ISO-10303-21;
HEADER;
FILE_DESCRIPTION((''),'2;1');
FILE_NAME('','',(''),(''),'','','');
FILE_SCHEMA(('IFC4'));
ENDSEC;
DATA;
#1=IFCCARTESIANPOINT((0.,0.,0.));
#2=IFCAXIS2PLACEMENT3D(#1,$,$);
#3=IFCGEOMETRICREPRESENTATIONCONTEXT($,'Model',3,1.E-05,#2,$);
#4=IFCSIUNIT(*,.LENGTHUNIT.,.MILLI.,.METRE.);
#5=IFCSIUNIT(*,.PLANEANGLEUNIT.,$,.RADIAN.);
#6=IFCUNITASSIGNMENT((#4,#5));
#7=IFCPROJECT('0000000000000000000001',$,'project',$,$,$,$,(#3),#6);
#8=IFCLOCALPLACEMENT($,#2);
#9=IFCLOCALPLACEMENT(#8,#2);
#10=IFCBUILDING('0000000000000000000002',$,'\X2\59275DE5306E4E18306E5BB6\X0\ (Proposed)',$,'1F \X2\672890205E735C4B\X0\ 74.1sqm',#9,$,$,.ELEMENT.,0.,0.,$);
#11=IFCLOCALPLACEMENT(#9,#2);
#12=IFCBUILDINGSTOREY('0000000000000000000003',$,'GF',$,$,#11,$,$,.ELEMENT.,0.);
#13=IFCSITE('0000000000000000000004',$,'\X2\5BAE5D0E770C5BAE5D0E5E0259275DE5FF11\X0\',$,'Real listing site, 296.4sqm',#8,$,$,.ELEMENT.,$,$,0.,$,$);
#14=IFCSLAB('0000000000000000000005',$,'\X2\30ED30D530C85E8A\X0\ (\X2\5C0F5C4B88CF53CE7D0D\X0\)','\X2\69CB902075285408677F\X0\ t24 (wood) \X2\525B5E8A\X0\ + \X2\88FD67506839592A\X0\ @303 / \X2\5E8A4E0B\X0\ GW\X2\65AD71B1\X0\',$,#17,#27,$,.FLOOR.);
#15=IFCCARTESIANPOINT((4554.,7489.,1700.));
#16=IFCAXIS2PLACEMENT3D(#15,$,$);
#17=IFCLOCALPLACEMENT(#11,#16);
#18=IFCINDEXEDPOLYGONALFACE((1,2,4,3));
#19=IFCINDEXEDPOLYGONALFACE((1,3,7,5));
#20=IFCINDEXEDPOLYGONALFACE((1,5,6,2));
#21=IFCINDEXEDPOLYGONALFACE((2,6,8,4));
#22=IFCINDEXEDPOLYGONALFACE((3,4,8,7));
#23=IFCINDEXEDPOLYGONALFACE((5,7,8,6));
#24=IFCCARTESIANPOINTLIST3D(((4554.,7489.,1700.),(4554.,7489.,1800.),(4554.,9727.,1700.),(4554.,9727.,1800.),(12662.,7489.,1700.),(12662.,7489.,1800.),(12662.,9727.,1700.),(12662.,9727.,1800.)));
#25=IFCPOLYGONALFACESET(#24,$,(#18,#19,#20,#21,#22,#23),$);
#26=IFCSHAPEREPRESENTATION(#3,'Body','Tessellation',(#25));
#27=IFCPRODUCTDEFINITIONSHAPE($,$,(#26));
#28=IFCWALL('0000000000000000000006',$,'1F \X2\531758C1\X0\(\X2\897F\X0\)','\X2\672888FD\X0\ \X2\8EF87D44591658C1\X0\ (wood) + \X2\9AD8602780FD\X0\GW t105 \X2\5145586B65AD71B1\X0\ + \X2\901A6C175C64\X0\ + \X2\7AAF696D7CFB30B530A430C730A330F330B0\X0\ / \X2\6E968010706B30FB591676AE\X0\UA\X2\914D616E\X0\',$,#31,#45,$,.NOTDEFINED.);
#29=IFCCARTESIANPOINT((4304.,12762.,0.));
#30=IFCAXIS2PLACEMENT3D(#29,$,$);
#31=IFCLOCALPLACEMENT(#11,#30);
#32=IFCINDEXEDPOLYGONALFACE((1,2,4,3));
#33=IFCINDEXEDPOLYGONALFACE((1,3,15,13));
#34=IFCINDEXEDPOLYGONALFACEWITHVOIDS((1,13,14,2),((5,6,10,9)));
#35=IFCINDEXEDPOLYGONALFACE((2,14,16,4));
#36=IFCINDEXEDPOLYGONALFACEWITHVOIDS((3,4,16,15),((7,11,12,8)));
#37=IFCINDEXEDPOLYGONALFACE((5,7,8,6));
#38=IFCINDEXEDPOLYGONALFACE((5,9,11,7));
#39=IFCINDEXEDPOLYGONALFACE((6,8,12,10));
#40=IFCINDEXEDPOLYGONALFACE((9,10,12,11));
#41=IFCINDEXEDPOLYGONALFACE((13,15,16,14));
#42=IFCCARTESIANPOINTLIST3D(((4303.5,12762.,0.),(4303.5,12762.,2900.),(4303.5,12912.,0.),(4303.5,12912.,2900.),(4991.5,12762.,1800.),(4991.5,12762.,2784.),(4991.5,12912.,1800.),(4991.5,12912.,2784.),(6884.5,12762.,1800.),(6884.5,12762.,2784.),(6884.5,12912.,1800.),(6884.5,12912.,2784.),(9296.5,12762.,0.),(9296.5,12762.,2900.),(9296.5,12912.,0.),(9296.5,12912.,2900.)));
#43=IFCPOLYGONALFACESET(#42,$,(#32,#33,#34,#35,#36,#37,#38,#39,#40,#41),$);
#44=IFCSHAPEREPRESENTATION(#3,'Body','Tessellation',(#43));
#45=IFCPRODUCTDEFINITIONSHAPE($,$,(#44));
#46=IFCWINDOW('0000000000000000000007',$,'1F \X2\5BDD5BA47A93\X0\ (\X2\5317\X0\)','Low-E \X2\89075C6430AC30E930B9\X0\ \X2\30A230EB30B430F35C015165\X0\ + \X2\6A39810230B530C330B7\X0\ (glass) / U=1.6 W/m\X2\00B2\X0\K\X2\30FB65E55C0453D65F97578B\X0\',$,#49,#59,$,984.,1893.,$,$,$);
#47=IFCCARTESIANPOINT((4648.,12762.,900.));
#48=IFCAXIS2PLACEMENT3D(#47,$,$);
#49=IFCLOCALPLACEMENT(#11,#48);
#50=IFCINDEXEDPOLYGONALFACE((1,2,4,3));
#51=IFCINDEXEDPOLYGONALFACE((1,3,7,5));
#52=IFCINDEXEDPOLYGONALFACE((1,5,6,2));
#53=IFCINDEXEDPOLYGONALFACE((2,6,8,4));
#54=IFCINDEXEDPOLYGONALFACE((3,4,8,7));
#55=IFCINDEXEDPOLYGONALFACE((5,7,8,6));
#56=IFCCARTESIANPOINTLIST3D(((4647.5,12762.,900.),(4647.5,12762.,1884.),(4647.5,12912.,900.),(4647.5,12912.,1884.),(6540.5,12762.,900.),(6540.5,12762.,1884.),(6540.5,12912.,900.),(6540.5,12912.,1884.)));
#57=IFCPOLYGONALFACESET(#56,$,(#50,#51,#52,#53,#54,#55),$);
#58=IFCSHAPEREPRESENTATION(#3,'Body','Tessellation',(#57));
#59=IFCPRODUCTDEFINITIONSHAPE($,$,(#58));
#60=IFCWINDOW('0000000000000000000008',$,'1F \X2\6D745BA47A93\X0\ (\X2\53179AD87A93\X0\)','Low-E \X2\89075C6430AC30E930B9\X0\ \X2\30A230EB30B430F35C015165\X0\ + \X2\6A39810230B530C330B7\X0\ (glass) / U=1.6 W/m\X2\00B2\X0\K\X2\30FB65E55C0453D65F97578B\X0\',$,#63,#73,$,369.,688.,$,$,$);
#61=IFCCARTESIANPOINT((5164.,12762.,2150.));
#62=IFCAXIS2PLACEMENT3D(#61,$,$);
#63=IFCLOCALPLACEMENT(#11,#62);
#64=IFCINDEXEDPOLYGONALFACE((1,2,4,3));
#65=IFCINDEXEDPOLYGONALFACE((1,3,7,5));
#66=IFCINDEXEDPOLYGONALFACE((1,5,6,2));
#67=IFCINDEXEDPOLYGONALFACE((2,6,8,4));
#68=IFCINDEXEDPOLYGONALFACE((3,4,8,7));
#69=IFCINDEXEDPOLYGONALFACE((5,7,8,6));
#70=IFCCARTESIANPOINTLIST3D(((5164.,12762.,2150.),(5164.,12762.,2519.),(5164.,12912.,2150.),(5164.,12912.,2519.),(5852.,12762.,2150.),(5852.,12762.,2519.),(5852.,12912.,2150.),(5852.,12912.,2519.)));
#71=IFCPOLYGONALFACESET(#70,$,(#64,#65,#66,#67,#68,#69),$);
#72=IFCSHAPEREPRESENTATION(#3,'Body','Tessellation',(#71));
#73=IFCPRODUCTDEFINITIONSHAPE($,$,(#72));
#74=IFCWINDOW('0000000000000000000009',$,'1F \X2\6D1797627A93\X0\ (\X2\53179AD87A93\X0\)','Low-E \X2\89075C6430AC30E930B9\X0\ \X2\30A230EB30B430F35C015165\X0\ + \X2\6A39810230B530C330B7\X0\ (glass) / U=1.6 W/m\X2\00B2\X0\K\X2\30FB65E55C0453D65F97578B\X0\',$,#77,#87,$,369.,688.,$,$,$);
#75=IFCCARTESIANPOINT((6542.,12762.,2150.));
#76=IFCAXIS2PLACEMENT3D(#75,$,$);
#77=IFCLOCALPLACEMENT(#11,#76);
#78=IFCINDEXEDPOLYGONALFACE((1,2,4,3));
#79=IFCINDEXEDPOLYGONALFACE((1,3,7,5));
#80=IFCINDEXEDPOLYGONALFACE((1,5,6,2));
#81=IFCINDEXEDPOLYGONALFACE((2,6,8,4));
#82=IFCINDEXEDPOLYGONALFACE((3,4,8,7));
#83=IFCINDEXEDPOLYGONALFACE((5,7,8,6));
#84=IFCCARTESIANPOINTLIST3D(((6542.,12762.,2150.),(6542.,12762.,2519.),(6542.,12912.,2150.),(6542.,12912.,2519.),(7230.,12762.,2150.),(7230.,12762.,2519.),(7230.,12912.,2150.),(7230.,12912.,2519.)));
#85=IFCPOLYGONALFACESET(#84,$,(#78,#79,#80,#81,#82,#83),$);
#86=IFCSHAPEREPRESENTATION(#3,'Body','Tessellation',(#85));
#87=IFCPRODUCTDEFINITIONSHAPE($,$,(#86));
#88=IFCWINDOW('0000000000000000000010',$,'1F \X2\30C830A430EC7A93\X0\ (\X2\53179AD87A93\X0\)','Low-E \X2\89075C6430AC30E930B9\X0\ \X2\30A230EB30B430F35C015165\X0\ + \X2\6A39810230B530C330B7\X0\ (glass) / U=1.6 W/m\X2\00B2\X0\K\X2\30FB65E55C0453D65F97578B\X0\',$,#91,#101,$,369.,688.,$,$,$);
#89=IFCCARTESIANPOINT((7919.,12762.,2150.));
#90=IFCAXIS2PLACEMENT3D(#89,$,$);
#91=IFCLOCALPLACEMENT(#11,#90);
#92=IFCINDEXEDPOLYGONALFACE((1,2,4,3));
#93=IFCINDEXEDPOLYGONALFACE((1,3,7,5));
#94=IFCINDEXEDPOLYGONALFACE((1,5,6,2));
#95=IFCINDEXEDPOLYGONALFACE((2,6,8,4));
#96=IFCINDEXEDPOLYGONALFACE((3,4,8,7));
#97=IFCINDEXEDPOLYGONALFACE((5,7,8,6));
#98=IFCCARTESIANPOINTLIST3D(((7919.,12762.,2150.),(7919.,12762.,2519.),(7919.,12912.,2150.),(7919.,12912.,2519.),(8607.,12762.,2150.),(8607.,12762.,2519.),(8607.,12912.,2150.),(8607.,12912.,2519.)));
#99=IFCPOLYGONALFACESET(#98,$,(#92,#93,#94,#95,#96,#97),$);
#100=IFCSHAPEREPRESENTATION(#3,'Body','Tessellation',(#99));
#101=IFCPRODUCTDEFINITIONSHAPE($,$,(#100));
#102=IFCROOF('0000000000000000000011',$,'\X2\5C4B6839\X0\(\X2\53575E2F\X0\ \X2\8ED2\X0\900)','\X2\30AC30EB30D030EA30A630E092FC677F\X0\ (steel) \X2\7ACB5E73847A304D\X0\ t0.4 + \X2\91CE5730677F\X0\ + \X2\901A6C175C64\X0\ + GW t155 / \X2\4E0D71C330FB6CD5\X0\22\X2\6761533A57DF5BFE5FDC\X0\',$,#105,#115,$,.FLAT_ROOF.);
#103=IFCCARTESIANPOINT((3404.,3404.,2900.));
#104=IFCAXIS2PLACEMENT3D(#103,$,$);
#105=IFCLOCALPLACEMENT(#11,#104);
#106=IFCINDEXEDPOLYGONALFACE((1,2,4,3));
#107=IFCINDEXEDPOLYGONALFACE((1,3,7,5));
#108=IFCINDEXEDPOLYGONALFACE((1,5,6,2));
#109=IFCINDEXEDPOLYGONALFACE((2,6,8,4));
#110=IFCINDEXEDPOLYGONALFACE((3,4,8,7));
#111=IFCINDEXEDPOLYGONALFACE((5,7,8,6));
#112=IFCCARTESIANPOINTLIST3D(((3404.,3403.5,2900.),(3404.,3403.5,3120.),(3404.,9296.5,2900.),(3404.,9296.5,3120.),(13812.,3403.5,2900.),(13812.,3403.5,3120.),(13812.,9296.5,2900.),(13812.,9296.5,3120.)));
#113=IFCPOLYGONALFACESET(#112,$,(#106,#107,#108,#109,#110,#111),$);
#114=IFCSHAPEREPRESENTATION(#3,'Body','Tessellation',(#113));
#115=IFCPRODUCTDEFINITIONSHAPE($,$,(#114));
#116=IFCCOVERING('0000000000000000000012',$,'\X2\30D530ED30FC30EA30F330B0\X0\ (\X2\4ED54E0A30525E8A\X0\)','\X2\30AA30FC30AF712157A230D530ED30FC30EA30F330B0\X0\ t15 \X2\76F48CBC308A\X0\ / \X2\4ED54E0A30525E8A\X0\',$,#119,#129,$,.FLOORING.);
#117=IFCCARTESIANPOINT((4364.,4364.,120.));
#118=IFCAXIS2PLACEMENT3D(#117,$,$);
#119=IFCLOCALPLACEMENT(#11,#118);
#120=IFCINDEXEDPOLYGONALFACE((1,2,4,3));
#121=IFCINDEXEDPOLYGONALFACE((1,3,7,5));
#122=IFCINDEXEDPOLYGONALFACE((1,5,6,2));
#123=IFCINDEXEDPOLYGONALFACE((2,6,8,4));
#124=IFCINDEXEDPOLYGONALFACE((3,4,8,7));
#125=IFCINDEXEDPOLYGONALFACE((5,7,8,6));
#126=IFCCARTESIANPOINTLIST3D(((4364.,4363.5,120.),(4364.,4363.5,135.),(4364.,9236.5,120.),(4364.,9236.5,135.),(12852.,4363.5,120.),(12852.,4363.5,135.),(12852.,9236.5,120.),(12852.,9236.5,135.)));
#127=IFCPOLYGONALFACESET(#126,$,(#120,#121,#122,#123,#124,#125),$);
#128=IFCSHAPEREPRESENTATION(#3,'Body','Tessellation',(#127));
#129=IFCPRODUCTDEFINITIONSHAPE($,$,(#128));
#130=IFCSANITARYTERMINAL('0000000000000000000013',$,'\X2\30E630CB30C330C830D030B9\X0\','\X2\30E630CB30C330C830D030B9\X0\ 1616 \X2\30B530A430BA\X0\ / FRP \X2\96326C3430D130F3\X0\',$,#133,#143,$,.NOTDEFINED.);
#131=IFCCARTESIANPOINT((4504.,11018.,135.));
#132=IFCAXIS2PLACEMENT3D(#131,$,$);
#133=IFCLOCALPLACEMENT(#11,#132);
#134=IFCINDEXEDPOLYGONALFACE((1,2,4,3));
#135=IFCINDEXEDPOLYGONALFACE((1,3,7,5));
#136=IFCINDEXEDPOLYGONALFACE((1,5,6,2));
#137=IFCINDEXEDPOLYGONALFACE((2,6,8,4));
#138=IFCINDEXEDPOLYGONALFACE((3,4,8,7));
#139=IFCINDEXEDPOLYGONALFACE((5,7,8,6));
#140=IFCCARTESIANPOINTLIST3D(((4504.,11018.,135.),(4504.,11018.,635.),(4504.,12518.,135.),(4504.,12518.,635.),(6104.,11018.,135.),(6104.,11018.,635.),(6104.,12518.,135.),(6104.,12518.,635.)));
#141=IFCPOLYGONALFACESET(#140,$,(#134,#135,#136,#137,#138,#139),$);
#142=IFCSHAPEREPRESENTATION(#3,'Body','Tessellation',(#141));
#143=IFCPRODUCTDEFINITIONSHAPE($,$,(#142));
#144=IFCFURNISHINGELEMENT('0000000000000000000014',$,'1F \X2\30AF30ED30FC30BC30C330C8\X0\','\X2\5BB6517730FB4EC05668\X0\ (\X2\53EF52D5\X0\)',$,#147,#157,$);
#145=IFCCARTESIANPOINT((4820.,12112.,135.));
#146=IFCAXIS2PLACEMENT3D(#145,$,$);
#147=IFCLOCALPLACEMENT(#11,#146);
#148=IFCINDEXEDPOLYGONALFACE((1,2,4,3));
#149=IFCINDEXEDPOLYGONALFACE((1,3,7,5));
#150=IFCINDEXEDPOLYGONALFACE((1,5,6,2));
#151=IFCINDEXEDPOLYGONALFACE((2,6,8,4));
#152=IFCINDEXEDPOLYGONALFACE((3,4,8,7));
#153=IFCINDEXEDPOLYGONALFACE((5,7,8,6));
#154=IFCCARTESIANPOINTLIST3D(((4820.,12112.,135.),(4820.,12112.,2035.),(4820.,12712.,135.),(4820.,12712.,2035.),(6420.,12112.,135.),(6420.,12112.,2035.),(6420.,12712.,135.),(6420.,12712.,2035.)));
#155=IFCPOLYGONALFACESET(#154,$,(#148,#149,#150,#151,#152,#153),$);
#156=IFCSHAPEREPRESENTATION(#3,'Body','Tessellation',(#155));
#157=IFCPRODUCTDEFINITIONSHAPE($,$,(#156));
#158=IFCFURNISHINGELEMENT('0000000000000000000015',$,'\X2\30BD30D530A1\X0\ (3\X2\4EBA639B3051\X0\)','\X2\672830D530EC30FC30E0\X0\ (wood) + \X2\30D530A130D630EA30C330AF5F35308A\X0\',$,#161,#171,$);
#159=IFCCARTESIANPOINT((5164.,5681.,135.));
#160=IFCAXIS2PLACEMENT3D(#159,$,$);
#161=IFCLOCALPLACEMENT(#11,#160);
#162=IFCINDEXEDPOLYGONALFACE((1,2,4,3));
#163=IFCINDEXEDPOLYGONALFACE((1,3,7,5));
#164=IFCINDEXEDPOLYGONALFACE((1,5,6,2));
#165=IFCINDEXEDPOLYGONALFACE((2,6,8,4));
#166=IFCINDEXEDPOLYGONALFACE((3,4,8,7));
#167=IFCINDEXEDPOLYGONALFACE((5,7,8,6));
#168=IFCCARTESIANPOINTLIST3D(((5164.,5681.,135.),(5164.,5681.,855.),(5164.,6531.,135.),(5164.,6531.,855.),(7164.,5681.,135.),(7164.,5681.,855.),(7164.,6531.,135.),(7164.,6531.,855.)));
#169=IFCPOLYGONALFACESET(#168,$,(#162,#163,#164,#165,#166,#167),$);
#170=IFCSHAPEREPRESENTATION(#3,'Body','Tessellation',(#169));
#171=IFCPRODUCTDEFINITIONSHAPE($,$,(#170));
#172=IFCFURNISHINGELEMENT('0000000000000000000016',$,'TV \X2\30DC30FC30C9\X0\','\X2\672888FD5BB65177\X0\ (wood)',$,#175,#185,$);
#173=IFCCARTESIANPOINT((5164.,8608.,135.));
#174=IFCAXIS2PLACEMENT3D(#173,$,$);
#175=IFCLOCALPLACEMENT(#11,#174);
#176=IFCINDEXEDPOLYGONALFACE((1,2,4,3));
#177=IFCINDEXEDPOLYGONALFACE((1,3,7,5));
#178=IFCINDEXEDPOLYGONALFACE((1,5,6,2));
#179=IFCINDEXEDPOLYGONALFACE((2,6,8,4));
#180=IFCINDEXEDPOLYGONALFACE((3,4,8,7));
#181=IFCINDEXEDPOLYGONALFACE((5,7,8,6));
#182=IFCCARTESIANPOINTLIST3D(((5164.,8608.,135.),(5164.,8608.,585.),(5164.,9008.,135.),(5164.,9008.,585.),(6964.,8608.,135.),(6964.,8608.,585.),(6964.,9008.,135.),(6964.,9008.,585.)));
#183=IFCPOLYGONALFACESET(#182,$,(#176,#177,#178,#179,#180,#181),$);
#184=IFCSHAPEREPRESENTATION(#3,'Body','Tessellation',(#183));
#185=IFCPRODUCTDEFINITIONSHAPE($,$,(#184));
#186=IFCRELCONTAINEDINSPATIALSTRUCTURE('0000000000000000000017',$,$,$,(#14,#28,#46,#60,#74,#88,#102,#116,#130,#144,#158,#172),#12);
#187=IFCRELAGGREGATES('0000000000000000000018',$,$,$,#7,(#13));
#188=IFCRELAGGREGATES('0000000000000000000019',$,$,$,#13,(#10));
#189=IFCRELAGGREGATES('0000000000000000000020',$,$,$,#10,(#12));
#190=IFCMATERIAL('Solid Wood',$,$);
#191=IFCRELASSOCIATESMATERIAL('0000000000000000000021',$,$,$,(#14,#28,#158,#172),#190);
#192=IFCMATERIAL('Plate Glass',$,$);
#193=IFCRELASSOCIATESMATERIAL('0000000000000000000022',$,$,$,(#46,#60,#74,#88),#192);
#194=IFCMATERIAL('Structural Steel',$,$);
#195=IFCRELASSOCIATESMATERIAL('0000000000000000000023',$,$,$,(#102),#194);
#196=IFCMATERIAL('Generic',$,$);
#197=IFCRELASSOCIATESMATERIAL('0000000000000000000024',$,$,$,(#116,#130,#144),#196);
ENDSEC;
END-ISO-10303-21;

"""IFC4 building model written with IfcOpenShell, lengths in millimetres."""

from ifc_helpers import new_model, si_unit, frame, frame_2d, origin, place, context, project, spatial, rectangle, extrude, material, element, fill, save


model = new_model("IFC4")

# Units and contexts
model_context = context("Model", 3, precision=1e-05, world=origin())
ifc_project = project(units=[si_unit("LENGTHUNIT", "METRE", prefix="MILLI"), si_unit("PLANEANGLEUNIT", "RADIAN")], contexts=[model_context])

# Site, building, storey
site_placement = place(None, origin())
site = spatial("IfcSite", under=ifc_project, at=site_placement, Name="宮崎県宮崎市大工１", ObjectType="Real listing site, 296.4sqm", CompositionType="ELEMENT", RefElevation=0.0)
building_placement = place(site_placement, origin())
building = spatial("IfcBuilding", under=site, at=building_placement, Name="大工の丘の家 (Proposed)", ObjectType="1F 木造平屋 74.1sqm", CompositionType="ELEMENT", ElevationOfRefHeight=0.0, ElevationOfTerrain=0.0)
storey_placement = place(building_placement, origin())
storey = spatial("IfcBuildingStorey", under=building, at=storey_placement, Name="GF", CompositionType="ELEMENT", Elevation=0.0)

# Slab
ifc_material_1 = material(Name="Solid Wood")
slab_1_placement = place(storey_placement, frame((4554.0, 7489.0, 1700.0)))
element("IfcSlab", 1, at=slab_1_placement, inside=storey, material=ifc_material_1, Name="ロフト床 (小屋裏収納)", Description="構造用合板 t24 (wood) 剛床 + 製材根太 @303 / 床下 GW断熱", PredefinedType="FLOOR", context=model_context, shape_type="SweptSolid", body=[
    extrude(rectangle(XDim=8108.0, YDim=2238.0, at=frame_2d((4054.0, 1119.0))), frame((4554.0, 7489.0, 1700.0)), (0.0, 0.0, 1.0), 100.0),
])

# Shared definitions
ifc_material_2 = material(Name="Plate Glass")

# Wall, openings, windows
wall_1_placement = place(storey_placement, frame((4304.0, 12762.0, 0.0)))
wall_1 = element("IfcWall", 2, at=wall_1_placement, inside=storey, material=ifc_material_1, Name="1F 北壁(西)", Description="木製 軸組外壁 (wood) + 高性能GW t105 充填断熱 + 通気層 + 窯業系サイディング / 準耐火・外皮UA配慮", PredefinedType="NOTDEFINED", context=model_context, shape_type="SweptSolid", body=[
    extrude(rectangle(XDim=4993.0, YDim=150.0, at=frame_2d((2496.0, 75.0))), frame((4304.0, 12762.0, 0.0)), (0.0, 0.0, 1.0), 2900.0),
])
opening_1_placement = place(storey_placement, frame((4648.0, 12762.0, 900.0)))
opening_1 = element("IfcOpeningElement", 3, at=opening_1_placement, cuts=wall_1, PredefinedType="NOTDEFINED", context=model_context, shape_type="SweptSolid", body=[
    extrude(rectangle(XDim=1893.0, YDim=150.0, at=frame_2d((946.0, 75.0))), frame((4648.0, 12762.0, 900.0)), (0.0, 0.0, 1.0), 984.0),
])
opening_2_placement = place(storey_placement, frame((5164.0, 12762.0, 2150.0)))
opening_2 = element("IfcOpeningElement", 4, at=opening_2_placement, cuts=wall_1, PredefinedType="NOTDEFINED", context=model_context, shape_type="SweptSolid", body=[
    extrude(rectangle(XDim=688.0, YDim=150.0, at=frame_2d((344.0, 75.0))), frame((5164.0, 12762.0, 2150.0)), (0.0, 0.0, 1.0), 369.0),
])
opening_3_placement = place(storey_placement, frame((6542.0, 12762.0, 2150.0)))
opening_3 = element("IfcOpeningElement", 5, at=opening_3_placement, cuts=wall_1, PredefinedType="NOTDEFINED", context=model_context, shape_type="SweptSolid", body=[
    extrude(rectangle(XDim=688.0, YDim=150.0, at=frame_2d((344.0, 75.0))), frame((6542.0, 12762.0, 2150.0)), (0.0, 0.0, 1.0), 369.0),
])
opening_4_placement = place(storey_placement, frame((7919.0, 12762.0, 2150.0)))
opening_4 = element("IfcOpeningElement", 6, at=opening_4_placement, cuts=wall_1, PredefinedType="NOTDEFINED", context=model_context, shape_type="SweptSolid", body=[
    extrude(rectangle(XDim=688.0, YDim=150.0, at=frame_2d((344.0, 75.0))), frame((7919.0, 12762.0, 2150.0)), (0.0, 0.0, 1.0), 369.0),
])
window_1_placement = place(storey_placement, frame((4648.0, 12762.0, 900.0)))
window_1 = element("IfcWindow", 7, at=window_1_placement, inside=storey, material=ifc_material_2, Name="1F 寝室窓 (北)", Description="Low-E 複層ガラス アルゴン封入 + 樹脂サッシ (glass) / U=1.6 W/m²K・日射取得型", OverallHeight=984.0, OverallWidth=1893.0, context=model_context, shape_type="SweptSolid", body=[
    extrude(rectangle(XDim=1893.0, YDim=150.0, at=frame_2d((946.0, 75.0))), frame((4648.0, 12762.0, 900.0)), (0.0, 0.0, 1.0), 984.0),
])
fill(opening_1, window_1)
window_2_placement = place(storey_placement, frame((5164.0, 12762.0, 2150.0)))
window_2 = element("IfcWindow", 8, at=window_2_placement, inside=storey, material=ifc_material_2, Name="1F 浴室窓 (北高窓)", Description="Low-E 複層ガラス アルゴン封入 + 樹脂サッシ (glass) / U=1.6 W/m²K・日射取得型", OverallHeight=369.0, OverallWidth=688.0, context=model_context, shape_type="SweptSolid", body=[
    extrude(rectangle(XDim=688.0, YDim=150.0, at=frame_2d((344.0, 75.0))), frame((5164.0, 12762.0, 2150.0)), (0.0, 0.0, 1.0), 369.0),
])
fill(opening_2, window_2)
window_3_placement = place(storey_placement, frame((6542.0, 12762.0, 2150.0)))
window_3 = element("IfcWindow", 9, at=window_3_placement, inside=storey, material=ifc_material_2, Name="1F 洗面窓 (北高窓)", Description="Low-E 複層ガラス アルゴン封入 + 樹脂サッシ (glass) / U=1.6 W/m²K・日射取得型", OverallHeight=369.0, OverallWidth=688.0, context=model_context, shape_type="SweptSolid", body=[
    extrude(rectangle(XDim=688.0, YDim=150.0, at=frame_2d((344.0, 75.0))), frame((6542.0, 12762.0, 2150.0)), (0.0, 0.0, 1.0), 369.0),
])
fill(opening_3, window_3)
window_4_placement = place(storey_placement, frame((7919.0, 12762.0, 2150.0)))
window_4 = element("IfcWindow", 10, at=window_4_placement, inside=storey, material=ifc_material_2, Name="1F トイレ窓 (北高窓)", Description="Low-E 複層ガラス アルゴン封入 + 樹脂サッシ (glass) / U=1.6 W/m²K・日射取得型", OverallHeight=369.0, OverallWidth=688.0, context=model_context, shape_type="SweptSolid", body=[
    extrude(rectangle(XDim=688.0, YDim=150.0, at=frame_2d((344.0, 75.0))), frame((7919.0, 12762.0, 2150.0)), (0.0, 0.0, 1.0), 369.0),
])
fill(opening_4, window_4)

# Roof
ifc_material_3 = material(Name="Structural Steel")
roof_1_placement = place(storey_placement, frame((3404.0, 3404.0, 2900.0)))
element("IfcRoof", 11, at=roof_1_placement, inside=storey, material=ifc_material_3, Name="屋根(南帯 軒900)", Description="ガルバリウム鋼板 (steel) 立平葺き t0.4 + 野地板 + 通気層 + GW t155 / 不燃・法22条区域対応", PredefinedType="FLAT_ROOF", context=model_context, shape_type="SweptSolid", body=[
    extrude(rectangle(XDim=10408.0, YDim=5893.0, at=frame_2d((5204.0, 2946.0))), frame((3404.0, 3404.0, 2900.0)), (0.0, 0.0, 1.0), 220.0),
])

# Covering
ifc_material_4 = material(Name="Generic")
covering_1_placement = place(storey_placement, frame((4364.0, 4364.0, 120.0)))
element("IfcCovering", 12, at=covering_1_placement, inside=storey, material=ifc_material_4, Name="フローリング (仕上げ床)", Description="オーク無垢フローリング t15 直貼り / 仕上げ床", PredefinedType="FLOORING", context=model_context, shape_type="SweptSolid", body=[
    extrude(rectangle(XDim=8488.0, YDim=4873.0, at=frame_2d((4244.0, 2436.0))), frame((4364.0, 4364.0, 120.0)), (0.0, 0.0, 1.0), 15.0),
])

# Sanitary terminal
sanitary_terminal_placement = place(storey_placement, frame((4504.0, 11018.0, 135.0)))
element("IfcSanitaryTerminal", 13, at=sanitary_terminal_placement, inside=storey, material=ifc_material_4, Name="ユニットバス", Description="ユニットバス 1616 サイズ / FRP 防水パン", PredefinedType="NOTDEFINED", context=model_context, shape_type="SweptSolid", body=[
    extrude(rectangle(XDim=1600.0, YDim=1500.0, at=frame_2d((800.0, 750.0))), frame((4504.0, 11018.0, 135.0)), (0.0, 0.0, 1.0), 500.0),
])

# Furnishing elements
furnishing_1_placement = place(storey_placement, frame((4820.0, 12112.0, 135.0)))
element("IfcFurnishingElement", 14, at=furnishing_1_placement, inside=storey, material=ifc_material_4, Name="1F クローゼット", Description="家具・什器 (可動)", context=model_context, shape_type="SweptSolid", body=[
    extrude(rectangle(XDim=1600.0, YDim=600.0, at=frame_2d((800.0, 300.0))), frame((4820.0, 12112.0, 135.0)), (0.0, 0.0, 1.0), 1900.0),
])
furnishing_2_placement = place(storey_placement, frame((5164.0, 5681.0, 135.0)))
element("IfcFurnishingElement", 15, at=furnishing_2_placement, inside=storey, material=ifc_material_1, Name="ソファ (3人掛け)", Description="木フレーム (wood) + ファブリック張り", context=model_context, shape_type="SweptSolid", body=[
    extrude(rectangle(XDim=2000.0, YDim=850.0, at=frame_2d((1000.0, 425.0))), frame((5164.0, 5681.0, 135.0)), (0.0, 0.0, 1.0), 720.0),
])
furnishing_3_placement = place(storey_placement, frame((5164.0, 8608.0, 135.0)))
element("IfcFurnishingElement", 16, at=furnishing_3_placement, inside=storey, material=ifc_material_1, Name="TV ボード", Description="木製家具 (wood)", context=model_context, shape_type="SweptSolid", body=[
    extrude(rectangle(XDim=1800.0, YDim=400.0, at=frame_2d((900.0, 200.0))), frame((5164.0, 8608.0, 135.0)), (0.0, 0.0, 1.0), 450.0),
])

save(model, "model.ifc")
